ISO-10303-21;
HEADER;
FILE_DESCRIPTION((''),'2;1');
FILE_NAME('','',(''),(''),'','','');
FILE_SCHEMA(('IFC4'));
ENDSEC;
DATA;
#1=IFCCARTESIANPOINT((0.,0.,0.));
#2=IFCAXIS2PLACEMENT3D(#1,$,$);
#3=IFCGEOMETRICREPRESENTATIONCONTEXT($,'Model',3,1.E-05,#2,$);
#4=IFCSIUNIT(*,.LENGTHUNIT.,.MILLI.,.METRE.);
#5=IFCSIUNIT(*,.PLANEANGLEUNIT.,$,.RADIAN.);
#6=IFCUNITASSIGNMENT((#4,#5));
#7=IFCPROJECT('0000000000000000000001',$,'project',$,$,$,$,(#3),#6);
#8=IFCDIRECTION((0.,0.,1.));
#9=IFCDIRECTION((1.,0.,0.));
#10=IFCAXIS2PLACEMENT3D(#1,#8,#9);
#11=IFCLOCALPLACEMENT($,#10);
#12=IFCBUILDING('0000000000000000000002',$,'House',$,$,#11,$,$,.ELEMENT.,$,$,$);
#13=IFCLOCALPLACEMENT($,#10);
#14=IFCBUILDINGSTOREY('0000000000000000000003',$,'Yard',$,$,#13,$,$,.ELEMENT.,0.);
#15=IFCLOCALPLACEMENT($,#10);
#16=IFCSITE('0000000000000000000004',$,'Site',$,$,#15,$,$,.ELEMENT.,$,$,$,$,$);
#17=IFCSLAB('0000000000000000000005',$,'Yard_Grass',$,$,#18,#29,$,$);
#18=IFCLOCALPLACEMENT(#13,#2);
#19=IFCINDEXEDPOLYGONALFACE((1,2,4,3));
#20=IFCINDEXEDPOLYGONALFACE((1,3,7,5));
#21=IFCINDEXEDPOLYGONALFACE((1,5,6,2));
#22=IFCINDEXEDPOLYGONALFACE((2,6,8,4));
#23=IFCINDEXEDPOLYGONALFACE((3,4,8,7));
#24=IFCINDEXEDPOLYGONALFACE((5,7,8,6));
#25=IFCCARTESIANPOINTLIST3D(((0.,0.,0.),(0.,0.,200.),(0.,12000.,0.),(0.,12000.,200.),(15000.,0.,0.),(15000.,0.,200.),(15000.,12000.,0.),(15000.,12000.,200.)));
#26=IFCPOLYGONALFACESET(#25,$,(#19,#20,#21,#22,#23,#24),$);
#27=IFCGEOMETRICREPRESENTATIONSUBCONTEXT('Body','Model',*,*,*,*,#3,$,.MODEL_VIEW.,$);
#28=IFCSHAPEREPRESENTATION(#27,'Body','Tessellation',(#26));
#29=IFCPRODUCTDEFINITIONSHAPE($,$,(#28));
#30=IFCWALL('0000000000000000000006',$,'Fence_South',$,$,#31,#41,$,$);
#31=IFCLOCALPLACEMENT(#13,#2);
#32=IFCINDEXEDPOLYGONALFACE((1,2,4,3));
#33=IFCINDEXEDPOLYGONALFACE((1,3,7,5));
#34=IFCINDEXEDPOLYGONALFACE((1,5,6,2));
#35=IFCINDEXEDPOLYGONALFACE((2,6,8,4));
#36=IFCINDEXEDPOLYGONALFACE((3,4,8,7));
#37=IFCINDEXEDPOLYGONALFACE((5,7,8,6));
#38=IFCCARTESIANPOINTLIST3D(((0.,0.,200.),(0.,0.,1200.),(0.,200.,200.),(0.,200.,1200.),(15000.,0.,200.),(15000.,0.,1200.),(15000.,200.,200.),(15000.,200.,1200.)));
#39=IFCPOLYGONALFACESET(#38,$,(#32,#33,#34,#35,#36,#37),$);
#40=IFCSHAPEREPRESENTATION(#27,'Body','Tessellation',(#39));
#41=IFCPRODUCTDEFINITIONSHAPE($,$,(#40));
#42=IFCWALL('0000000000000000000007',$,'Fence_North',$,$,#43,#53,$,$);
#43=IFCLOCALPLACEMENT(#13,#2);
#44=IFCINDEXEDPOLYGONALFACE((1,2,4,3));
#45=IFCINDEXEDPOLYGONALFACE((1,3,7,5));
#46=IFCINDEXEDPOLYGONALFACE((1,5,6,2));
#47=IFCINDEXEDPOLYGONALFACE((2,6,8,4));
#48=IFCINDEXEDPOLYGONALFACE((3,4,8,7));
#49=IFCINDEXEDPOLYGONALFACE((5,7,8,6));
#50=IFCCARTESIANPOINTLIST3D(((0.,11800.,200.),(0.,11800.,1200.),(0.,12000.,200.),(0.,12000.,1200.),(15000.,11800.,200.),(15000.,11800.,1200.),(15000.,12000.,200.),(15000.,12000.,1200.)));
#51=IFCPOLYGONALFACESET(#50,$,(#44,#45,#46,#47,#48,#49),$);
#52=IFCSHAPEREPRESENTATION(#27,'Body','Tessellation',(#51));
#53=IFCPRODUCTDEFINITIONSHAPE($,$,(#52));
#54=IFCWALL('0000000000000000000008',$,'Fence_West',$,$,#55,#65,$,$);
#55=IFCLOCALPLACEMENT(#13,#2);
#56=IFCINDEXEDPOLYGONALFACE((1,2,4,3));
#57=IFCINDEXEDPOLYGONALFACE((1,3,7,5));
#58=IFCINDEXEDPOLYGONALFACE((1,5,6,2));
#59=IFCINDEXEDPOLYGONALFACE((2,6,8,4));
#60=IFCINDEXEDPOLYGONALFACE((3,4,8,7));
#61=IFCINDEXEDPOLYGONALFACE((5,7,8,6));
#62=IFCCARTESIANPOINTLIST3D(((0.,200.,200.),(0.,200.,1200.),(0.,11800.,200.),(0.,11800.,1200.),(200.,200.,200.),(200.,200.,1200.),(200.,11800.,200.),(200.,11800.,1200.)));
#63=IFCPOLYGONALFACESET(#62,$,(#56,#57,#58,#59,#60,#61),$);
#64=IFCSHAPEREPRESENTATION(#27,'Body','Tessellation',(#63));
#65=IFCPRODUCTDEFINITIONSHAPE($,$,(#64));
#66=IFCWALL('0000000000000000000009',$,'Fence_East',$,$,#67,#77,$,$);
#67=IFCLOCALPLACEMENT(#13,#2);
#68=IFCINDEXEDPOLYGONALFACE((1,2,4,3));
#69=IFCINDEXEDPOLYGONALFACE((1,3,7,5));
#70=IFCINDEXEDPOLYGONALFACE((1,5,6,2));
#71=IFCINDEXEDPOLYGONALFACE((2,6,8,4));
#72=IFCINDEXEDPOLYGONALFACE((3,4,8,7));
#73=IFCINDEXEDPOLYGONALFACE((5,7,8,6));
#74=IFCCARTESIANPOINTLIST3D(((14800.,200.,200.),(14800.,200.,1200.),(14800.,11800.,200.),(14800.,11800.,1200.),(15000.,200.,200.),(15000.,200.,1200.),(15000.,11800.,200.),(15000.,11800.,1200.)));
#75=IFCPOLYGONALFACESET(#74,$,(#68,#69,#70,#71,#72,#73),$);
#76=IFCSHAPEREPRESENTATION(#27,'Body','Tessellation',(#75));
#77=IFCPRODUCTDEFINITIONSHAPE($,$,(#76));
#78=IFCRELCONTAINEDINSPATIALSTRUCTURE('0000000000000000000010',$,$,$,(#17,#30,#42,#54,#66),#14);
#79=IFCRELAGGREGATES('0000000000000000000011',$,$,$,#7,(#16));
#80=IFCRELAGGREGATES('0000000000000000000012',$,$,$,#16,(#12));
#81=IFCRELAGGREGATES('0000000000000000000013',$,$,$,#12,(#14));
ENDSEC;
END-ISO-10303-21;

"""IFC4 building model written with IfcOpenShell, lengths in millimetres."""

from ifc_helpers import new_model, si_unit, frame, origin, origin_with_axes, place, context, subcontext, project, spatial, rectangle, extrude, element, save


model = new_model("IFC4")

# Units and contexts
model_context = context("Model", 3, precision=1e-05, world=origin())
body_context = subcontext(model_context, "Body", "Model", "MODEL_VIEW")
ifc_project = project(units=[si_unit("LENGTHUNIT", "METRE", prefix="MILLI"), si_unit("PLANEANGLEUNIT", "RADIAN")], contexts=[model_context])

# Site, building, storey
site_placement = place(None, origin_with_axes())
site = spatial("IfcSite", under=ifc_project, at=site_placement, Name="Site", CompositionType="ELEMENT")
building_placement = place(None, origin_with_axes())
building = spatial("IfcBuilding", under=site, at=building_placement, Name="House", CompositionType="ELEMENT")
storey_placement = place(None, origin_with_axes())
storey = spatial("IfcBuildingStorey", under=building, at=storey_placement, Name="Yard", CompositionType="ELEMENT", Elevation=0.0)

# Slab
slab_placement = place(None, origin_with_axes())
element("IfcSlab", 1, at=slab_placement, inside=storey, Name="Yard_Grass", context=body_context, shape_type="SweptSolid", body=[
    extrude(rectangle(XDim=15000.0, YDim=12000.0), frame((7500.0, 6000.0, 0.0)), (0.0, 0.0, 1.0), 200.0),
])

# Walls
for number, where, z_axis, x_axis, name in (
    (2, (0.0, 0.0, 200.0), (0.0, 0.0, 1.0), (1.0, 0.0, 0.0), "Fence_South"),
    (3, (0.0, 11800.0, 200.0), (0.0, 0.0, 1.0), (1.0, 0.0, 0.0), "Fence_North"),
):
    element("IfcWall", number, at=place(None, frame(where, z_axis=z_axis, x_axis=x_axis)), inside=storey, Name=name, context=body_context, shape_type="SweptSolid", body=[
        extrude(rectangle(XDim=15000.0, YDim=200.0), frame((7500.0, 100.0, 0.0)), (0.0, 0.0, 1.0), 1000.0),
    ])
for number, where, z_axis, x_axis, name in (
    (4, (0.0, 200.0, 200.0), (0.0, 0.0, 1.0), (1.0, 0.0, 0.0), "Fence_West"),
    (5, (14800.0, 200.0, 200.0), (0.0, 0.0, 1.0), (1.0, 0.0, 0.0), "Fence_East"),
):
    element("IfcWall", number, at=place(None, frame(where, z_axis=z_axis, x_axis=x_axis)), inside=storey, Name=name, context=body_context, shape_type="SweptSolid", body=[
        extrude(rectangle(XDim=200.0, YDim=11600.0), frame((100.0, 5800.0, 0.0)), (0.0, 0.0, 1.0), 1000.0),
    ])

save(model, "model.ifc")
